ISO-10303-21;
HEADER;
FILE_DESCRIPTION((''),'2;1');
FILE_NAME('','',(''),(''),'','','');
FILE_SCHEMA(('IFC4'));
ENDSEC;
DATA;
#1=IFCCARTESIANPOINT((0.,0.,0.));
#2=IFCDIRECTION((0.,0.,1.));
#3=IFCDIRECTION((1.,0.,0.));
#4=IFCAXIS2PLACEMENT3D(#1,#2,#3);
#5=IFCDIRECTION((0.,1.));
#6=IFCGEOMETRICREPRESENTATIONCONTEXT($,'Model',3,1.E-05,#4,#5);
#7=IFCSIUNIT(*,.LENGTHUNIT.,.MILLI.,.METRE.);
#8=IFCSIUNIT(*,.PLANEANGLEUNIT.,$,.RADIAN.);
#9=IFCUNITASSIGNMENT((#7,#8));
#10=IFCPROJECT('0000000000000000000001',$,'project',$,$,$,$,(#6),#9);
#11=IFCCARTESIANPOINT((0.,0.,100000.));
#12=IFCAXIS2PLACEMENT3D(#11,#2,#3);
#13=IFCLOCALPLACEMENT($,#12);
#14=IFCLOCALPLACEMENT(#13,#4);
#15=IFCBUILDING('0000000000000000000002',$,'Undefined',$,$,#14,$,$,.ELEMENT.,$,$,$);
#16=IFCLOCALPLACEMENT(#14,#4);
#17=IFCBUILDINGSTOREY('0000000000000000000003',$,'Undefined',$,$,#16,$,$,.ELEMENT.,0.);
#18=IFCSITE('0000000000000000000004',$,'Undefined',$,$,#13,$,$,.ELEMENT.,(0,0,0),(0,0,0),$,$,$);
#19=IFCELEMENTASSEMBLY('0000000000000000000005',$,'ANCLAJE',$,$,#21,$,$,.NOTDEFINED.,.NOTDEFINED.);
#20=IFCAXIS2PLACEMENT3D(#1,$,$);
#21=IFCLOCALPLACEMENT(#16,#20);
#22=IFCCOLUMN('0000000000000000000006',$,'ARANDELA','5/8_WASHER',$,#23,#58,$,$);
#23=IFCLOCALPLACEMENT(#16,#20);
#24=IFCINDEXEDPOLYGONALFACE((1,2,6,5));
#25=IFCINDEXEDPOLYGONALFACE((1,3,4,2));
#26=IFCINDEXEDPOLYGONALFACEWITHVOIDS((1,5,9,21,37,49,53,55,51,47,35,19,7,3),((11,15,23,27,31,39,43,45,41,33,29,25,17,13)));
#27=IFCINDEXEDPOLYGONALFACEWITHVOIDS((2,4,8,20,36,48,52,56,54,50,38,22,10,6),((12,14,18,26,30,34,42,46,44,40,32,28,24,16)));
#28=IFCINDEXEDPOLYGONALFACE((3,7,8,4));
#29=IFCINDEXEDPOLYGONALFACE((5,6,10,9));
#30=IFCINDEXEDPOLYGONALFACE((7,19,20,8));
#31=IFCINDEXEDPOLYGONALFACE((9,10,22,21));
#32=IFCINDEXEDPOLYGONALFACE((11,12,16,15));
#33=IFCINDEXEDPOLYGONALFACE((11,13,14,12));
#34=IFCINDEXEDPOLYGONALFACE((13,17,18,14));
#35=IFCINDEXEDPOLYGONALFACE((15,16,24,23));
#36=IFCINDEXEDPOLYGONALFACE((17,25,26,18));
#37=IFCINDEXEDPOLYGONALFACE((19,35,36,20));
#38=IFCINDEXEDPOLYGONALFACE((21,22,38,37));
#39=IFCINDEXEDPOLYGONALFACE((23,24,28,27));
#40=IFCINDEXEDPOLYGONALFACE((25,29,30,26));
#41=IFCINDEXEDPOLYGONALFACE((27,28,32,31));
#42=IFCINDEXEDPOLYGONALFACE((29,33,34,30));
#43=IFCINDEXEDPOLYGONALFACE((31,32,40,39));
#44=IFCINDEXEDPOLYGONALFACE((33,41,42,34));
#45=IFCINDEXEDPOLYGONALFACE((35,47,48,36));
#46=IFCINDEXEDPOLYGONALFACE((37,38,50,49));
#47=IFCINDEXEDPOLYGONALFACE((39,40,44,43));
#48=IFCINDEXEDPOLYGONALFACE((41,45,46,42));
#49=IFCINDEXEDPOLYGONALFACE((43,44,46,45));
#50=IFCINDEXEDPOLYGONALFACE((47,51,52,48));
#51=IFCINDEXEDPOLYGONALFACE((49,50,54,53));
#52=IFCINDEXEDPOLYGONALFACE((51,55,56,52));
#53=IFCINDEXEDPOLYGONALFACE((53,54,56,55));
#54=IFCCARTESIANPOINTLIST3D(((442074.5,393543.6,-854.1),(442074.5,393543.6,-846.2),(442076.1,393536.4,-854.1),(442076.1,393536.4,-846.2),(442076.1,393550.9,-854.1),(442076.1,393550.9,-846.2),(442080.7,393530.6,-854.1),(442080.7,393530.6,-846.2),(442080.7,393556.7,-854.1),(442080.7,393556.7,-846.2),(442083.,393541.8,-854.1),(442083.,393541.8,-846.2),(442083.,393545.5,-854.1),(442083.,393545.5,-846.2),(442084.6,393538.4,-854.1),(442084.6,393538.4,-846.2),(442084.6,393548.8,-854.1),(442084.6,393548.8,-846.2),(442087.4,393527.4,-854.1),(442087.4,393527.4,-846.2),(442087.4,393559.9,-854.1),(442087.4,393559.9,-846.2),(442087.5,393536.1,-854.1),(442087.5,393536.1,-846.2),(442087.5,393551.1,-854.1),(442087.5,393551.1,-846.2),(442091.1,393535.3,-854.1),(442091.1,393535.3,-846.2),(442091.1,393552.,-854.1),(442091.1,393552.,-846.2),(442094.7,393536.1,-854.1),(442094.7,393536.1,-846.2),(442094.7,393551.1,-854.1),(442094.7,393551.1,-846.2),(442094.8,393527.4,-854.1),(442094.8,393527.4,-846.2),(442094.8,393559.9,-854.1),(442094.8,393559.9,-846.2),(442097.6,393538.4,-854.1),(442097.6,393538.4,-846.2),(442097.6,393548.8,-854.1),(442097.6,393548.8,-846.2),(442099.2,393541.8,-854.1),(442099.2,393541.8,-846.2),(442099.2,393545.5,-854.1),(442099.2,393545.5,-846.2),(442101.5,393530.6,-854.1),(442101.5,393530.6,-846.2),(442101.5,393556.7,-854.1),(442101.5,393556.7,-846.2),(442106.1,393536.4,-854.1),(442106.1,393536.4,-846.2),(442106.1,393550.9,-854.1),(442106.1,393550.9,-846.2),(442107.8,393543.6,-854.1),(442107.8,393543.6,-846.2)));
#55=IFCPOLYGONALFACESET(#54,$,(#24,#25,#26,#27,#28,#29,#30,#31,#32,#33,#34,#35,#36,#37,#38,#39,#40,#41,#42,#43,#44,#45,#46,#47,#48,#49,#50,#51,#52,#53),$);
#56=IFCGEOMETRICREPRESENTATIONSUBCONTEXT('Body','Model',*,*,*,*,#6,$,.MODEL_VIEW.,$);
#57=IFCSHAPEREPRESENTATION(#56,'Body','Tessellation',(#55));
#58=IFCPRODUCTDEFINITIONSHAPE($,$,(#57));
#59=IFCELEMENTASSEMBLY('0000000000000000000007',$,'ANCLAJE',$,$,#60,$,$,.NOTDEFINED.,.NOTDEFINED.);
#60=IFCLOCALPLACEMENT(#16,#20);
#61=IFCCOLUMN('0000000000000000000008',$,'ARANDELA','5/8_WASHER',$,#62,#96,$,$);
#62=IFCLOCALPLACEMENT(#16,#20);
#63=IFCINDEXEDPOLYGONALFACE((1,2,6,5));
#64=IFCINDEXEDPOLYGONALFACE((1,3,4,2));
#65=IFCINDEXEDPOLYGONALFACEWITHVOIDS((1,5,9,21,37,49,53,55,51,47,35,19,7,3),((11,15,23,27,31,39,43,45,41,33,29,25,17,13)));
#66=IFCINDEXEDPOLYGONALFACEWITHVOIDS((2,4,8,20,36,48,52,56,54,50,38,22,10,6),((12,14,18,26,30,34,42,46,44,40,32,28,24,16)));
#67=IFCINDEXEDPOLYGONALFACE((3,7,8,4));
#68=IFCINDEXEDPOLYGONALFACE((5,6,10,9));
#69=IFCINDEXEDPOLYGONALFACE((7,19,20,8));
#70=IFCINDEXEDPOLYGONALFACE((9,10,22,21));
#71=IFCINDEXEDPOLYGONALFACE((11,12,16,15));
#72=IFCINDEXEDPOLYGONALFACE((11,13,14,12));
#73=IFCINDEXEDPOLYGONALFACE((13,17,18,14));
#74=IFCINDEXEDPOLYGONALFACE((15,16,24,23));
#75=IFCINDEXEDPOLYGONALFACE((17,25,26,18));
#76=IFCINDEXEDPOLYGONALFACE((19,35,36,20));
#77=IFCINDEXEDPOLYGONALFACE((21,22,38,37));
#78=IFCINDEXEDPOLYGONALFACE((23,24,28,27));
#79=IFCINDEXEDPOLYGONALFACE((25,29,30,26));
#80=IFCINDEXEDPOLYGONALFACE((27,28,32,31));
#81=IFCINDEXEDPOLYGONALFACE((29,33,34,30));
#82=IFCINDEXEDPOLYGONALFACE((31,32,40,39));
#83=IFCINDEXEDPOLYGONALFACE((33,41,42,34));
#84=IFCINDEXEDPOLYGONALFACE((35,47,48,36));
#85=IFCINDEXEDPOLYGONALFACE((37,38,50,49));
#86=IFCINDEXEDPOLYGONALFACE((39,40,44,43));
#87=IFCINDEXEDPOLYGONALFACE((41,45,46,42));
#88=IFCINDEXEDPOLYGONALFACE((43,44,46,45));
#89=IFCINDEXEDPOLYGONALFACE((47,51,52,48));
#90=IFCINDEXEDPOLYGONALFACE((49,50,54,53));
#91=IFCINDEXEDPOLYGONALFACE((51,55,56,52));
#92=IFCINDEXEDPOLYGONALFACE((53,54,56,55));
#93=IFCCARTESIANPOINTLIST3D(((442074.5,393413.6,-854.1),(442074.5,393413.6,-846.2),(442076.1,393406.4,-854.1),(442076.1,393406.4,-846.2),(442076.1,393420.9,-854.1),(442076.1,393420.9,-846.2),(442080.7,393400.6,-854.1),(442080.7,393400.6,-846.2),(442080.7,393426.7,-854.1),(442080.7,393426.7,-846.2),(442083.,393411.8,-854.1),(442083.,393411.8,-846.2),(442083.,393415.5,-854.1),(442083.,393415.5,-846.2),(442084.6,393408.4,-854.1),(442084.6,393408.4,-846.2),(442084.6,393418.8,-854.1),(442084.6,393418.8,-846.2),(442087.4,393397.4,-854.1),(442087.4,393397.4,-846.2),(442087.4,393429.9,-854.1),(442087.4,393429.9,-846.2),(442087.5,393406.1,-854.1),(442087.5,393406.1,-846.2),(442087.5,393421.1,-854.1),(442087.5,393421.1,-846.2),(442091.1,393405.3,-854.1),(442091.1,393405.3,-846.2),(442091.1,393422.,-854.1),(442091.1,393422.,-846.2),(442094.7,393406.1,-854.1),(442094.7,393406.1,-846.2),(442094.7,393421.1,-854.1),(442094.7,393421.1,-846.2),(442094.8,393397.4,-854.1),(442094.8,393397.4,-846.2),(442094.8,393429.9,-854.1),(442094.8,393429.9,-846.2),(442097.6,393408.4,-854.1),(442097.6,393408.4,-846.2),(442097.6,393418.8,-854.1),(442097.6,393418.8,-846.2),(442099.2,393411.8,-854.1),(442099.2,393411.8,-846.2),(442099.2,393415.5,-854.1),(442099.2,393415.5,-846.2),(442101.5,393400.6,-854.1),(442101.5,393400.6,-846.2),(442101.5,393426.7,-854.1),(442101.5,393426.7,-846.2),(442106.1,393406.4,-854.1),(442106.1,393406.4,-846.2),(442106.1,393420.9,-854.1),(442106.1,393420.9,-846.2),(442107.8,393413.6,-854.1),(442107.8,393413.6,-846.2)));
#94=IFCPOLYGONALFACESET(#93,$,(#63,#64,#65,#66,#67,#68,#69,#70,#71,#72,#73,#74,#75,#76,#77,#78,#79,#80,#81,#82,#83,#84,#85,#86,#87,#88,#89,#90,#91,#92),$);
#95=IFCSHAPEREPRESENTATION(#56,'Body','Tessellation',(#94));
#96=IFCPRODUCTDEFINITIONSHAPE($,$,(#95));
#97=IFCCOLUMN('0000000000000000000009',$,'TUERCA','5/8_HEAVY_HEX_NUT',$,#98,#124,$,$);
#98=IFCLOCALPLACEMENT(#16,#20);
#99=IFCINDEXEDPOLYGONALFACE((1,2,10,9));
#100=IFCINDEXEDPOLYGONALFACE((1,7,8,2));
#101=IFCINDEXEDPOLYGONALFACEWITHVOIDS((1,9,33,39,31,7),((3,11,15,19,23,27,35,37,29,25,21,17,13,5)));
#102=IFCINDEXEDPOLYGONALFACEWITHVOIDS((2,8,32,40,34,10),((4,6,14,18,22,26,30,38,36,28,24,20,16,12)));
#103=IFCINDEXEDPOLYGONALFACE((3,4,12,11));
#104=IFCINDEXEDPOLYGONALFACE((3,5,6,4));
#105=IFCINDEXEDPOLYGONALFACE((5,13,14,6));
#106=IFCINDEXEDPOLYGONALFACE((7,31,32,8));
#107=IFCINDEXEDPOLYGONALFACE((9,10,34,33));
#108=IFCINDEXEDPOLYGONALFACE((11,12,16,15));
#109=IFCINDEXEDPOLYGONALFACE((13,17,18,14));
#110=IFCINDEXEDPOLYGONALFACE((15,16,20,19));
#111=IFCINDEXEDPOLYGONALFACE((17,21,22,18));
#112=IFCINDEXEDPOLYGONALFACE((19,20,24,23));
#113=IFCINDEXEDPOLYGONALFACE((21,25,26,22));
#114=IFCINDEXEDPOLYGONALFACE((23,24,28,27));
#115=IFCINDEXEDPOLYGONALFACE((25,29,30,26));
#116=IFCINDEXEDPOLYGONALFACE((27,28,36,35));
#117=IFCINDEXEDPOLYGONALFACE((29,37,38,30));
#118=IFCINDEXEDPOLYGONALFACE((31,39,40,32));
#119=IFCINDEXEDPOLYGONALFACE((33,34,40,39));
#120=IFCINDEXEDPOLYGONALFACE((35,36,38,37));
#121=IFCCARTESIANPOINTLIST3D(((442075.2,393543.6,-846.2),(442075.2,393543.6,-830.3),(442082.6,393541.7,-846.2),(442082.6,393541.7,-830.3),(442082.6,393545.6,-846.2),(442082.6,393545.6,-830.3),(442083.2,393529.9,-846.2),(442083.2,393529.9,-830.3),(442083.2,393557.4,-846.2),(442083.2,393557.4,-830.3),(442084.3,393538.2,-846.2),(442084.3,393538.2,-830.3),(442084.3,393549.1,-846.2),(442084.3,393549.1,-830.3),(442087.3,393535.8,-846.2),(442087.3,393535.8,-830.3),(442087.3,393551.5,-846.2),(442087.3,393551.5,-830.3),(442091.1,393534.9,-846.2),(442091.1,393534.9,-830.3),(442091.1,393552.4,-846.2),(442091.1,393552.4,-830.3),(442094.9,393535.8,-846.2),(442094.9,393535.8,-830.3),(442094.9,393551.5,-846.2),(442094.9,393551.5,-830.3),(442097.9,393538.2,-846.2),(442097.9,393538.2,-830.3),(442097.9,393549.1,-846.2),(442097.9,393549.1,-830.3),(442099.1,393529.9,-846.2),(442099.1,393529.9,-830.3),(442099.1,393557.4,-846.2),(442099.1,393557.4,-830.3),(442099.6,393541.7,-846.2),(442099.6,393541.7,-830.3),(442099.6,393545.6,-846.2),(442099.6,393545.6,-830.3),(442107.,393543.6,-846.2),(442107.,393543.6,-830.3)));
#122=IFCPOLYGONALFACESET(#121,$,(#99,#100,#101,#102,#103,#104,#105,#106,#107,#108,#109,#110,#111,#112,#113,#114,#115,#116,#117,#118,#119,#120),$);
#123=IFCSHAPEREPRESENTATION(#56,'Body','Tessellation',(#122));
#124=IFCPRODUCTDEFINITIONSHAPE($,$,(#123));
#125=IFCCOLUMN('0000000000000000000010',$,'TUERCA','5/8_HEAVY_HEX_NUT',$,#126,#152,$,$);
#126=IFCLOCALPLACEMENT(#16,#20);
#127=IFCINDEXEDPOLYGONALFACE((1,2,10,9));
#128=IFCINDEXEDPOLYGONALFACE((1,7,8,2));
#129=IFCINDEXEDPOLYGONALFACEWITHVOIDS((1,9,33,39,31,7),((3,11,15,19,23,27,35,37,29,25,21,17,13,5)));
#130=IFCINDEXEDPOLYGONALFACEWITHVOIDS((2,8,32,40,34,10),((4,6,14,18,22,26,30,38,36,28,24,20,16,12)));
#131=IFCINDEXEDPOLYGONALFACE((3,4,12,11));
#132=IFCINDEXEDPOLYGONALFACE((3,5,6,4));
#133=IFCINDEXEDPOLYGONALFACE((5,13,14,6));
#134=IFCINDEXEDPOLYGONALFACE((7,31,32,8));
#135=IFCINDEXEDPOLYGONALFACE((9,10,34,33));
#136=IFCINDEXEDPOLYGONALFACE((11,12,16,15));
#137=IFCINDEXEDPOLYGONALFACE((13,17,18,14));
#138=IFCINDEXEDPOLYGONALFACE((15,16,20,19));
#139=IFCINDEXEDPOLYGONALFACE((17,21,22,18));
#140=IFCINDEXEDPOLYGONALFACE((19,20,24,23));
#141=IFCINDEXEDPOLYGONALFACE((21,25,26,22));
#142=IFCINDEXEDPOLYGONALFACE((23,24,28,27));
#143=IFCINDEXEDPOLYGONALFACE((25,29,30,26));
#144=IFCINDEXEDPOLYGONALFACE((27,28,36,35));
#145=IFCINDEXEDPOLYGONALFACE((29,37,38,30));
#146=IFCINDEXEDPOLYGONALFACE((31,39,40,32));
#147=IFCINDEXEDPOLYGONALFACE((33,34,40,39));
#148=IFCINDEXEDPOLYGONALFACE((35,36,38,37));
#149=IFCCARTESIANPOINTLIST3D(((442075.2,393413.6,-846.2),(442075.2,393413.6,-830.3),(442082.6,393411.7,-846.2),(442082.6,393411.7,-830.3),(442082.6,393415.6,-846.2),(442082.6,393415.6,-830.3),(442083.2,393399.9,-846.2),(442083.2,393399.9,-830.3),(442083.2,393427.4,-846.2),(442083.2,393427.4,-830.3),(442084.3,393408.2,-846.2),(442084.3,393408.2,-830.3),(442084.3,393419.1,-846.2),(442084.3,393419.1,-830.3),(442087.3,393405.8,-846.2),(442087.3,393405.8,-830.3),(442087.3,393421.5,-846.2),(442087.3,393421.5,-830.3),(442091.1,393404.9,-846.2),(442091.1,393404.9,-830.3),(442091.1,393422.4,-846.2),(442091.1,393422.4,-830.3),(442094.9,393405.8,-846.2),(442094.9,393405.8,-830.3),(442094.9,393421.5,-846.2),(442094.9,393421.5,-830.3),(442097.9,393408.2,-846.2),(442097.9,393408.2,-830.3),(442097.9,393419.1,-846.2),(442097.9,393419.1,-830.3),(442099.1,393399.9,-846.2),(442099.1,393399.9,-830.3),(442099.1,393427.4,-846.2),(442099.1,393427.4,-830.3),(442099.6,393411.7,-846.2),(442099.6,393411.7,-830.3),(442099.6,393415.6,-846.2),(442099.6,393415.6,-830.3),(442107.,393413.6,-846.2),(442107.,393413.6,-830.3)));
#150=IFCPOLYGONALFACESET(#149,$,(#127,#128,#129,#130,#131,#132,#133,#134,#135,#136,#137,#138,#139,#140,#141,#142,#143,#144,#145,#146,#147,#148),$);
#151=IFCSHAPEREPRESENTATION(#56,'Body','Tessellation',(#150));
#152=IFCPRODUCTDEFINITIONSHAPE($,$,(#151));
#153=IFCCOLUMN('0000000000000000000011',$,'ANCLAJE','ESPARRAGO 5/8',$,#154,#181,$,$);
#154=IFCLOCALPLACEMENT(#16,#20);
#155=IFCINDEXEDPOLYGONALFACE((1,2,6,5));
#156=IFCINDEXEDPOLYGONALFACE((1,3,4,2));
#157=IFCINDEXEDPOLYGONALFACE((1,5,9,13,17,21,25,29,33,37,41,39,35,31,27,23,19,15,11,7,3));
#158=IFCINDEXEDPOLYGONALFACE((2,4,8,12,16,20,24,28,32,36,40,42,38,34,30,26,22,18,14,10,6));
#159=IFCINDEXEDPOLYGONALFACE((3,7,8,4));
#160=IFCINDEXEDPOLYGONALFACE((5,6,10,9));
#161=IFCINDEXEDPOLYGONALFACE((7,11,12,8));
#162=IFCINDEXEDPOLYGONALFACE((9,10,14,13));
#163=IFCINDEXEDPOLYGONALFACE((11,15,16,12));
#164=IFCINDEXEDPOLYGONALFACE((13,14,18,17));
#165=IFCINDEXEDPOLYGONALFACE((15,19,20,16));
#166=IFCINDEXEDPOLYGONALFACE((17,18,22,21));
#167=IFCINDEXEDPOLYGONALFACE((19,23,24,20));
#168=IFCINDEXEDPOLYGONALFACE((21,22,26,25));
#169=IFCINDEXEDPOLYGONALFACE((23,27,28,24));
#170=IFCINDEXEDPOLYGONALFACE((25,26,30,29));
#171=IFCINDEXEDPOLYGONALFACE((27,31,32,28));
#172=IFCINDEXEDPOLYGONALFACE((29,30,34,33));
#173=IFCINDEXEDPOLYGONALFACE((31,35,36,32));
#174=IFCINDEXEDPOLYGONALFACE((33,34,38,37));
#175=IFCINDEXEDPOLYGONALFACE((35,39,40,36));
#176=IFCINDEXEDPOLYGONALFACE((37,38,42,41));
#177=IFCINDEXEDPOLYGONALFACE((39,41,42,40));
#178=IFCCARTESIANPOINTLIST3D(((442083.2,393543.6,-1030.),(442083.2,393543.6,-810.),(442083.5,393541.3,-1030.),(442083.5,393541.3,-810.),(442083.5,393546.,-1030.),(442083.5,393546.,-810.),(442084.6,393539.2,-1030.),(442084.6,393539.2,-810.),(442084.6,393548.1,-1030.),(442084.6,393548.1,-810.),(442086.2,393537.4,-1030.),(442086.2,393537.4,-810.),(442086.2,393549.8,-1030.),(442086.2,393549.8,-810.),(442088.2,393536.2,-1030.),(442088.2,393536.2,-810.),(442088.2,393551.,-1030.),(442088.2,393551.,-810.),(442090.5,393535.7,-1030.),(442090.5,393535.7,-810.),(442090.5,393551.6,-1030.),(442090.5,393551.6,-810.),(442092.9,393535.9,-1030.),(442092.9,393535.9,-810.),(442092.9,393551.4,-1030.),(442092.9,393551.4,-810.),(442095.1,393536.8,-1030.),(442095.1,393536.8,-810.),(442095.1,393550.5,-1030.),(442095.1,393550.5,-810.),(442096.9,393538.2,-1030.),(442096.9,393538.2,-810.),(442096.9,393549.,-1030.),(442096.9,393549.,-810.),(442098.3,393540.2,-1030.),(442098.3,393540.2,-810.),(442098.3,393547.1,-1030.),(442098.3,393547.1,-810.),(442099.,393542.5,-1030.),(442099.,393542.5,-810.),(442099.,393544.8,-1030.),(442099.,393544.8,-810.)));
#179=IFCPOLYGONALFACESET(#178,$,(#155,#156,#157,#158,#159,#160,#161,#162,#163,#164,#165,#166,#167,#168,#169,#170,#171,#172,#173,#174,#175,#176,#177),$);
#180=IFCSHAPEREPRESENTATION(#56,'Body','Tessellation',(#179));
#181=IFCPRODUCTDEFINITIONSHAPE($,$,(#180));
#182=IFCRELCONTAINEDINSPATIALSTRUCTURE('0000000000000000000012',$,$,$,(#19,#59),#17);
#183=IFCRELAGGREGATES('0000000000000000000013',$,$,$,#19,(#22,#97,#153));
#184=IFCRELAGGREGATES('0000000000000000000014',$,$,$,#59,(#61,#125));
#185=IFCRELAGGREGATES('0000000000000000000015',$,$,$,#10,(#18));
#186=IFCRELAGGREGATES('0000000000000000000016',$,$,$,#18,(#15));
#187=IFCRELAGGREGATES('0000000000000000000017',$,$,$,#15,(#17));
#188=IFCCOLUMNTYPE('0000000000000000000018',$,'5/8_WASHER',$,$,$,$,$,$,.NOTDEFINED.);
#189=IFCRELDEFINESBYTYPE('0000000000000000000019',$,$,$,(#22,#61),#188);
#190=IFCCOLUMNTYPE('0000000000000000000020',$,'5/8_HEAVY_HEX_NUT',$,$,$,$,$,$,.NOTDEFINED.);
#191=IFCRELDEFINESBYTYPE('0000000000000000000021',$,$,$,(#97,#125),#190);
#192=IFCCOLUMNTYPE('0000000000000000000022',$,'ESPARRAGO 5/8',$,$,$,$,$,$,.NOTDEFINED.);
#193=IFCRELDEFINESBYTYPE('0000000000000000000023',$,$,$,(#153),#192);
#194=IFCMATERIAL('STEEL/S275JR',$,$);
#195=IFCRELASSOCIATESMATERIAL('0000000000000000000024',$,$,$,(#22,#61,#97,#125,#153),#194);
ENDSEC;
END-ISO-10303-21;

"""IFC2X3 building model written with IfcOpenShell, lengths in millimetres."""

from ifc_helpers import new_model, si_unit, direction, frame, origin_with_axes, origin_2d_with_axis, place, context, subcontext, project, spatial, polyline, circle, outline, extrude, material, type_object, element, aggregate, save


model = new_model("IFC2X3")

# Units and contexts
model_context = context("Model", 3, precision=1e-05, world=origin_with_axes(), true_north=direction((0.0, 1.0)))
body_context = subcontext(model_context, "Body", "Model", "MODEL_VIEW")
ifc_project = project(units=[si_unit("LENGTHUNIT", "METRE", prefix="MILLI"), si_unit("PLANEANGLEUNIT", "RADIAN")], contexts=[model_context])

# Site, building, storey
site_placement = place(None, frame((0.0, 0.0, 100000.0), z_axis=(0.0, 0.0, 1.0), x_axis=(1.0, 0.0, 0.0)))
site = spatial("IfcSite", under=ifc_project, at=site_placement, Name="Undefined", CompositionType="ELEMENT", RefLatitude=(0, 0, 0), RefLongitude=(0, 0, 0))
building_placement = place(site_placement, origin_with_axes())
building = spatial("IfcBuilding", under=site, at=building_placement, Name="Undefined", CompositionType="ELEMENT")
storey_placement = place(building_placement, origin_with_axes())
storey = spatial("IfcBuildingStorey", under=building, at=storey_placement, Name="Undefined", CompositionType="ELEMENT", Elevation=0.0)

# Element assemblies, columns
assembly_1_placement = place(storey_placement, origin_with_axes())
assembly_1 = element("IfcElementAssembly", 1, at=assembly_1_placement, inside=storey, Name="ANCLAJE", AssemblyPlace="NOTDEFINED", PredefinedType="NOTDEFINED")
ifc_material_1 = material(Name="STEEL/S275JR")
column_type_1 = type_object("IfcColumnType", Name="5/8_WASHER", PredefinedType="NOTDEFINED")
column_1_placement = place(assembly_1_placement, frame((442091.1, 393543.6, -846.2), z_axis=(0.0, 0.0, -1.0), x_axis=(0.0, -1.0, 0.0)))
column_1 = element("IfcColumn", 2, at=column_1_placement, type_object=column_type_1, material=ifc_material_1, Name="ARANDELA", Description="5/8_WASHER", context=body_context, shape_type="SweptSolid", body=[
    extrude(outline(polyline([(10.4, 13.0), (15.0, 7.2), (16.7, 0.0), (15.0, -7.2), (10.4, -13.0), (3.7, -16.3), (-3.7, -16.3), (-10.4, -13.0), (-15.0, -7.2), (-16.7, 0.0), (-15.0, 7.2), (-10.4, 13.0), (-3.7, 16.3), (3.7, 16.3), (10.4, 13.0)]), holes=[polyline([(6.5, -5.2), (8.1, -1.9), (8.1, 1.9), (6.5, 5.2), (3.6, 7.5), (0.0, 8.3), (-3.6, 7.5), (-6.5, 5.2), (-8.1, 1.9), (-8.1, -1.9), (-6.5, -5.2), (-3.6, -7.5), (0.0, -8.3), (3.6, -7.5), (6.5, -5.2)])]), frame((0.0, 0.0, 7.9), z_axis=(0.0, 0.0, -1.0), x_axis=(0.0, 1.0, 0.0)), (0.0, 0.0, 1.0), 7.9),
])
assembly_2_placement = place(storey_placement, origin_with_axes())
assembly_2 = element("IfcElementAssembly", 3, at=assembly_2_placement, inside=storey, Name="ANCLAJE", AssemblyPlace="NOTDEFINED", PredefinedType="NOTDEFINED")
column_2_placement = place(assembly_2_placement, frame((442091.1, 393413.6, -846.2), z_axis=(0.0, 0.0, -1.0), x_axis=(0.0, -1.0, 0.0)))
column_2 = element("IfcColumn", 4, at=column_2_placement, type_object=column_type_1, material=ifc_material_1, Name="ARANDELA", Description="5/8_WASHER", context=body_context, shape_type="SweptSolid", body=[
    extrude(outline(polyline([(10.4, 13.0), (15.0, 7.2), (16.7, 0.0), (15.0, -7.2), (10.4, -13.0), (3.7, -16.3), (-3.7, -16.3), (-10.4, -13.0), (-15.0, -7.2), (-16.7, 0.0), (-15.0, 7.2), (-10.4, 13.0), (-3.7, 16.3), (3.7, 16.3), (10.4, 13.0)]), holes=[polyline([(6.5, -5.2), (8.1, -1.9), (8.1, 1.9), (6.5, 5.2), (3.6, 7.5), (0.0, 8.3), (-3.6, 7.5), (-6.5, 5.2), (-8.1, 1.9), (-8.1, -1.9), (-6.5, -5.2), (-3.6, -7.5), (0.0, -8.3), (3.6, -7.5), (6.5, -5.2)])]), frame((0.0, 0.0, 7.9), z_axis=(0.0, 0.0, -1.0), x_axis=(0.0, 1.0, 0.0)), (0.0, 0.0, 1.0), 7.9),
])

# Columns
column_type_2 = type_object("IfcColumnType", Name="5/8_HEAVY_HEX_NUT", PredefinedType="NOTDEFINED")
column_3_placement = place(assembly_1_placement, frame((442091.1, 393543.6, -830.3), z_axis=(0.0, 0.0, -1.0), x_axis=(0.0, -1.0, 0.0)))
column_3 = element("IfcColumn", 5, at=column_3_placement, type_object=column_type_2, material=ifc_material_1, Name="TUERCA", Description="5/8_HEAVY_HEX_NUT", context=body_context, shape_type="SweptSolid", body=[
    extrude(outline(polyline([(-7.9, -13.7), (-15.9, 0.0), (-7.9, 13.7), (7.9, 13.7), (15.9, 0.0), (7.9, -13.7), (-7.9, -13.7)]), holes=[polyline([(3.8, 7.9), (0.0, 8.7), (-3.8, 7.9), (-6.8, 5.4), (-8.5, 1.9), (-8.5, -1.9), (-6.8, -5.4), (-3.8, -7.9), (0.0, -8.7), (3.8, -7.9), (6.8, -5.4), (8.5, -1.9), (8.5, 1.9), (6.8, 5.4), (3.8, 7.9)])]), frame((0.0, 0.0, 15.9), z_axis=(0.0, 0.0, -1.0), x_axis=(0.0, 1.0, 0.0)), (0.0, 0.0, 1.0), 15.9),
])
column_4_placement = place(assembly_2_placement, frame((442091.1, 393413.6, -830.3), z_axis=(0.0, 0.0, -1.0), x_axis=(0.0, -1.0, 0.0)))
column_4 = element("IfcColumn", 6, at=column_4_placement, type_object=column_type_2, material=ifc_material_1, Name="TUERCA", Description="5/8_HEAVY_HEX_NUT", context=body_context, shape_type="SweptSolid", body=[
    extrude(outline(polyline([(-7.9, -13.7), (-15.9, 0.0), (-7.9, 13.7), (7.9, 13.7), (15.9, 0.0), (7.9, -13.7), (-7.9, -13.7)]), holes=[polyline([(3.8, 7.9), (0.0, 8.7), (-3.8, 7.9), (-6.8, 5.4), (-8.5, 1.9), (-8.5, -1.9), (-6.8, -5.4), (-3.8, -7.9), (0.0, -8.7), (3.8, -7.9), (6.8, -5.4), (8.5, -1.9), (8.5, 1.9), (6.8, 5.4), (3.8, 7.9)])]), frame((0.0, 0.0, 15.9), z_axis=(0.0, 0.0, -1.0), x_axis=(0.0, 1.0, 0.0)), (0.0, 0.0, 1.0), 15.9),
])
column_type_3 = type_object("IfcColumnType", Name="ESPARRAGO 5/8", PredefinedType="NOTDEFINED")
column_5_placement = place(assembly_1_placement, frame((442091.1, 393543.6, -810.0), z_axis=(0.0, 0.0, -1.0), x_axis=(0.0, -1.0, 0.0)))
column_5 = element("IfcColumn", 7, at=column_5_placement, type_object=column_type_3, material=ifc_material_1, Name="ANCLAJE", Description="ESPARRAGO 5/8", context=body_context, shape_type="SweptSolid", body=[
    extrude(circle(Radius=7.9, at=origin_2d_with_axis()), frame((0.0, 0.0, 220.0), z_axis=(0.0, 0.0, -1.0), x_axis=(0.0, 1.0, 0.0)), (0.0, 0.0, 1.0), 220.0),
])
aggregate(assembly_1, [column_1, column_3, column_5])
aggregate(assembly_2, [column_2, column_4])

save(model, "model.ifc")
